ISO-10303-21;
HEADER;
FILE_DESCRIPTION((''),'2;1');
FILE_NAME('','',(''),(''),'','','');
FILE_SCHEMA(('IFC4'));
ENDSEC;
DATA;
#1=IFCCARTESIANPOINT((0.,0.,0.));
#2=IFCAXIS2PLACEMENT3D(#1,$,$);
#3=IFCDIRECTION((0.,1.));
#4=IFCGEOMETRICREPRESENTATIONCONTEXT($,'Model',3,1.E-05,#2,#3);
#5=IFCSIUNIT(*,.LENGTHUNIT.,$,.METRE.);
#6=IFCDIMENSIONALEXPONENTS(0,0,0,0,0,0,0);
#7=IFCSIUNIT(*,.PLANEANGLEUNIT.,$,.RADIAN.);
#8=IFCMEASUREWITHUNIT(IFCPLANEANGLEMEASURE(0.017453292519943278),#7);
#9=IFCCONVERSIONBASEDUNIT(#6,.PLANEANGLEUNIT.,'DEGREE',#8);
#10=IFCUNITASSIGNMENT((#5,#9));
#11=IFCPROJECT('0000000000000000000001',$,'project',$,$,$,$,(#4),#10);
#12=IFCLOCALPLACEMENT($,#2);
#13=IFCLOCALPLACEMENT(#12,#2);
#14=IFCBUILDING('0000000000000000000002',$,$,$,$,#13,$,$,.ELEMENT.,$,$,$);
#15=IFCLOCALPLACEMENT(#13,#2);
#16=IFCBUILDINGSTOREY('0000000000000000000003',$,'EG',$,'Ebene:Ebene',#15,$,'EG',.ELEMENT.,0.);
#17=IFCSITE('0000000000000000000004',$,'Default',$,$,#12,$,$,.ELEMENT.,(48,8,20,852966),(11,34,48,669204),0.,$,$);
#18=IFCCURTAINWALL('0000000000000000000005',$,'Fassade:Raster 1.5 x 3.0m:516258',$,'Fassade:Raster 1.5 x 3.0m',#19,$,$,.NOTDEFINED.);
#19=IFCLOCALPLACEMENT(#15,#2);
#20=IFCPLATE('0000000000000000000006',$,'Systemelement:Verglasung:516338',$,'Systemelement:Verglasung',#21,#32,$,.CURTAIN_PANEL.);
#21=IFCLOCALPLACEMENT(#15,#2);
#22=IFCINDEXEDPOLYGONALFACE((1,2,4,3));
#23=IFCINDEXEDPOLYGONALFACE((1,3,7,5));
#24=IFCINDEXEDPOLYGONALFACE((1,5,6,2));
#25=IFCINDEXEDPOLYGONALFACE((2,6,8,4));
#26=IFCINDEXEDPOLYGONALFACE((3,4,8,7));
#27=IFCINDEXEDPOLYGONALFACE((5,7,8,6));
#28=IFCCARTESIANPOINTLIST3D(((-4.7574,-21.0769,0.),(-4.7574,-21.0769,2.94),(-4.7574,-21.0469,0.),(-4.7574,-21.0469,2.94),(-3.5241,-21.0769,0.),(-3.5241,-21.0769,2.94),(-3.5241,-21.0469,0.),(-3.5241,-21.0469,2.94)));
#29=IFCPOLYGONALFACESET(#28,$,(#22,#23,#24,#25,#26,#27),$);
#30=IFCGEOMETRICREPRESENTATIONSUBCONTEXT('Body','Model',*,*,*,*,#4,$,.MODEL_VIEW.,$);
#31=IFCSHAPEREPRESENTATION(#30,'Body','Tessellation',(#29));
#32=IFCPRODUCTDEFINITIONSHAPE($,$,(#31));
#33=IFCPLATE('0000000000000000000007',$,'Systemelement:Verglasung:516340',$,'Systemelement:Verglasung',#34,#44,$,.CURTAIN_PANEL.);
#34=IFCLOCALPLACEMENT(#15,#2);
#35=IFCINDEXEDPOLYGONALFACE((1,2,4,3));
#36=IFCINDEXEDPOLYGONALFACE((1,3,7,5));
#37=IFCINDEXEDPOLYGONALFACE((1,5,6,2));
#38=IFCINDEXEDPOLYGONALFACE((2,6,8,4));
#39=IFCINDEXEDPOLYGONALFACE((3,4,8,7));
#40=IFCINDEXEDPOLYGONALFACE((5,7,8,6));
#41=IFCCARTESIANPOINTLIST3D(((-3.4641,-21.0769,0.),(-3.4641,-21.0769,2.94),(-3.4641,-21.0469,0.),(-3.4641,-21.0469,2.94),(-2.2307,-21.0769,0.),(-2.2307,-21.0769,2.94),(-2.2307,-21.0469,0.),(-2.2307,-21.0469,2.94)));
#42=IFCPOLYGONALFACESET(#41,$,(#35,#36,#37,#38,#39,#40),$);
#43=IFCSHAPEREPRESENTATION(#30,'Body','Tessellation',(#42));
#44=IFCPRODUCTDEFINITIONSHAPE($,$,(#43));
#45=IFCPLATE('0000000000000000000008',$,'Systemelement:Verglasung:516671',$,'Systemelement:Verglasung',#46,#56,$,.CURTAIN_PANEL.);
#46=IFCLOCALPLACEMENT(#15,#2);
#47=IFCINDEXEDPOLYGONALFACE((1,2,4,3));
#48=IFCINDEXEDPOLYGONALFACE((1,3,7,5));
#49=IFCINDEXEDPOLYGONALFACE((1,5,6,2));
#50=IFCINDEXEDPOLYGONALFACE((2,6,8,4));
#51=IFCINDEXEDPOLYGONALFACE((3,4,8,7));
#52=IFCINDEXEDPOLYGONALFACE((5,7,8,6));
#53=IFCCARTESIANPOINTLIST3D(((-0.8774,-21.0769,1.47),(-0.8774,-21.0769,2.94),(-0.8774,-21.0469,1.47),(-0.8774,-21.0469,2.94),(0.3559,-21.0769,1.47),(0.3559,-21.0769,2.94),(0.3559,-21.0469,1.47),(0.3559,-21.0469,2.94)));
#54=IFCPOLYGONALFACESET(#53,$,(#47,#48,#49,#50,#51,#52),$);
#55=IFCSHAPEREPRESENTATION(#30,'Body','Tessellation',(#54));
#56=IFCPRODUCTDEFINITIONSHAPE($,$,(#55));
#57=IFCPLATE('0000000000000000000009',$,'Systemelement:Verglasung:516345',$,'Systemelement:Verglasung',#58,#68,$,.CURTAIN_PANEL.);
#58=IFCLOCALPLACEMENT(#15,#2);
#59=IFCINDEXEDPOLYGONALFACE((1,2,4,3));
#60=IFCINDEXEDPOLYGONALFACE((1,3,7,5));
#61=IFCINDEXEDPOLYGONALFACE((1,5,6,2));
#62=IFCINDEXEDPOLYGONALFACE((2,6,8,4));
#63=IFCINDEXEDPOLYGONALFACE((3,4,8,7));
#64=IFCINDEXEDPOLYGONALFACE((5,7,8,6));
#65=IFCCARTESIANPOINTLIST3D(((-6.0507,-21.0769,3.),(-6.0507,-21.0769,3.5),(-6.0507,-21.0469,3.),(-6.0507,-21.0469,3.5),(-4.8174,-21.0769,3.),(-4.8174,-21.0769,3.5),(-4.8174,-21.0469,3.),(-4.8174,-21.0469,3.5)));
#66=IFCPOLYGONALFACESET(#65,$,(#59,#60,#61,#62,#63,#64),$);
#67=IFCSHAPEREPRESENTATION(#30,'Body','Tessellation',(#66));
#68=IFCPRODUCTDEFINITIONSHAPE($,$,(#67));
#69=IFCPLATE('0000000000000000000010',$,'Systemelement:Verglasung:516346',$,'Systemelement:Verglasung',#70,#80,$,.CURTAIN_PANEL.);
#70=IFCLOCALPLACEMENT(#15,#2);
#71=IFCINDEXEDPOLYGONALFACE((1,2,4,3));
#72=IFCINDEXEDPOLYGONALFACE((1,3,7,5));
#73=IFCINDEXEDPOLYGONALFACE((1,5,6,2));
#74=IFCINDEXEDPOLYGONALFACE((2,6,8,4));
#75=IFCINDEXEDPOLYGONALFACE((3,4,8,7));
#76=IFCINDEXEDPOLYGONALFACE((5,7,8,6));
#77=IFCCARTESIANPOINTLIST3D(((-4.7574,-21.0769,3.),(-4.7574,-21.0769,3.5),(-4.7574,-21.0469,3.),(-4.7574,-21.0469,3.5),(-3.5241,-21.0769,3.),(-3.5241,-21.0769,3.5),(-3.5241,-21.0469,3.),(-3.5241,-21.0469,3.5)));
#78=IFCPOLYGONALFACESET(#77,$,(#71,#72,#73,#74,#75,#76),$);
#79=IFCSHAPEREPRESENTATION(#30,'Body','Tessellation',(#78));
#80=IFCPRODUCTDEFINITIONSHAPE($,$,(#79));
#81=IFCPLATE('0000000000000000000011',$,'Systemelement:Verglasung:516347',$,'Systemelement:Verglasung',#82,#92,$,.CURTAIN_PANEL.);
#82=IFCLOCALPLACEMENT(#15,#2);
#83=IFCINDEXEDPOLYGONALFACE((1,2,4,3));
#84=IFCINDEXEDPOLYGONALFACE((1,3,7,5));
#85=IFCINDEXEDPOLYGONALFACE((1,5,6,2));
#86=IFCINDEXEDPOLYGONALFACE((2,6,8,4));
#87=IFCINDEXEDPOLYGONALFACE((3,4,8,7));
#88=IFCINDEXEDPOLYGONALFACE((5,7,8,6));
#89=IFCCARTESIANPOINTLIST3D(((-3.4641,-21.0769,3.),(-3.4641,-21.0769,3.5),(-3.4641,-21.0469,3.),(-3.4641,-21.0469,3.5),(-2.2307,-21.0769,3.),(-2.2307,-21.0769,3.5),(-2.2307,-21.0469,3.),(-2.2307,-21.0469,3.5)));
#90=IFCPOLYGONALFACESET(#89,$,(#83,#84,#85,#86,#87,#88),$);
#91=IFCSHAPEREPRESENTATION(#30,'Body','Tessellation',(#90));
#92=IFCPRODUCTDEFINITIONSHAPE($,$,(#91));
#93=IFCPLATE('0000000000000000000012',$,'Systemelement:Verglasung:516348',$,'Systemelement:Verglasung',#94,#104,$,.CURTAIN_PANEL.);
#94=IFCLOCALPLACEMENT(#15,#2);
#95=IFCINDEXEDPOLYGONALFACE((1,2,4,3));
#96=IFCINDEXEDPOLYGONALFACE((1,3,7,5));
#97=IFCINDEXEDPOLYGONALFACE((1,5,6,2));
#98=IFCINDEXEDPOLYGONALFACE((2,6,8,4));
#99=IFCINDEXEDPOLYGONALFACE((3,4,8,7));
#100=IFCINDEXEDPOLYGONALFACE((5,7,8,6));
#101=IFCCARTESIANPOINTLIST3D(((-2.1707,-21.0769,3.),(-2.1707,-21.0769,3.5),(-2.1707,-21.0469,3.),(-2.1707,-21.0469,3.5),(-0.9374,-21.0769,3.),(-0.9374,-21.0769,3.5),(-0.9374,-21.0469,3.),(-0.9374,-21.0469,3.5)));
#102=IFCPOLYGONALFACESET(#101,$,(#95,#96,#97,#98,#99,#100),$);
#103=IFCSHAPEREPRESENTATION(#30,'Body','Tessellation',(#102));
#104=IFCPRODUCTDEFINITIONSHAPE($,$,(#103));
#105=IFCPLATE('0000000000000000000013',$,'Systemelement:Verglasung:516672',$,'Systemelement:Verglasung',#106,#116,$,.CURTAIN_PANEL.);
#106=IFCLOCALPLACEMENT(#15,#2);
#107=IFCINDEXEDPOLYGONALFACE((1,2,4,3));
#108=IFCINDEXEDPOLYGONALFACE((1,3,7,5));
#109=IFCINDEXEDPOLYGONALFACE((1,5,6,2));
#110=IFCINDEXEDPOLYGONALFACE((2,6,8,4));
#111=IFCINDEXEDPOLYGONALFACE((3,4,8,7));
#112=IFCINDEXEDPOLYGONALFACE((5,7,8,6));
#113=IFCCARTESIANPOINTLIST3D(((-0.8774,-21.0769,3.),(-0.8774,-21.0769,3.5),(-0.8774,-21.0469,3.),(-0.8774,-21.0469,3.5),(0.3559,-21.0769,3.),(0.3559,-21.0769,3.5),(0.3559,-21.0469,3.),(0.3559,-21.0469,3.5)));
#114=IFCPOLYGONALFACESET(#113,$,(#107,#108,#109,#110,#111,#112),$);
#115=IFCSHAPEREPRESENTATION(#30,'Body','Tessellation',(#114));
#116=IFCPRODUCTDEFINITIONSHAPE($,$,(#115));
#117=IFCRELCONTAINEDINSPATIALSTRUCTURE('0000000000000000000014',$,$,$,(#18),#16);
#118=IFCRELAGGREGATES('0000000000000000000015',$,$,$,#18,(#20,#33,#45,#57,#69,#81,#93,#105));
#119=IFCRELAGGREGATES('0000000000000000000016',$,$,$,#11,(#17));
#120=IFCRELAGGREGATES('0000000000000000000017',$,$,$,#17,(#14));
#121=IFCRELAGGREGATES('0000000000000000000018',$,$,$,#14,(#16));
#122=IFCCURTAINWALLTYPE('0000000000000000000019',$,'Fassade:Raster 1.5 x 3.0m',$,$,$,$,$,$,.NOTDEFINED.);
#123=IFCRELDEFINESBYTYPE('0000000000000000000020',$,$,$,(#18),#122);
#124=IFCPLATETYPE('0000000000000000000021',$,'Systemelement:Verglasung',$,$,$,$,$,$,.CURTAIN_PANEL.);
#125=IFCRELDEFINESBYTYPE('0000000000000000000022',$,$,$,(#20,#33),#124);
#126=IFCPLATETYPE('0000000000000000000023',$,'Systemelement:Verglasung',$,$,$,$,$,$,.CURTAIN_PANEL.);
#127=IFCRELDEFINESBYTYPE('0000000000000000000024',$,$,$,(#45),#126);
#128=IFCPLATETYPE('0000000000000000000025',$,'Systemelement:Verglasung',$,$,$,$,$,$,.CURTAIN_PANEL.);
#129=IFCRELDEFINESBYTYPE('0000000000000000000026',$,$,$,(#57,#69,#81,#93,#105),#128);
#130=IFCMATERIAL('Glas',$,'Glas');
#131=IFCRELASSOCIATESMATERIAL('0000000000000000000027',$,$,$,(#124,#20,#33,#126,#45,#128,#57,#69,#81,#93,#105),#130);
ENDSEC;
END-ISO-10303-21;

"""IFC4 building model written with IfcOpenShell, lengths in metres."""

from ifc_helpers import new_model, entity, si_unit, converted_unit, direction, frame, origin, place, context, subcontext, project, spatial, indexed_curve, outline, extrude, source, transform, mapped, material, type_object, type_shapes, element, aggregate, save


model = new_model("IFC4")

# Units and contexts
model_context = context("Model", 3, precision=1e-05, world=origin(), true_north=direction((0.0, 1.0)))
body_context = subcontext(model_context, "Body", "Model", "MODEL_VIEW")
ifc_project = project(units=[si_unit("LENGTHUNIT", "METRE"), converted_unit("PLANEANGLEUNIT", "DEGREE", entity("IfcPlaneAngleMeasure", 0.017453292519943278), si_unit("PLANEANGLEUNIT", "RADIAN"), dimensions=[0, 0, 0, 0, 0, 0, 0])], contexts=[model_context])

# Site, building, storey
site_placement = place(None, origin())
site = spatial("IfcSite", under=ifc_project, at=site_placement, Name="Default", CompositionType="ELEMENT", RefLatitude=(48, 8, 20, 852966), RefLongitude=(11, 34, 48, 669204), RefElevation=0.0)
building_placement = place(site_placement, origin())
building = spatial("IfcBuilding", under=site, at=building_placement, CompositionType="ELEMENT")
storey_placement = place(building_placement, origin())
storey = spatial("IfcBuildingStorey", under=building, at=storey_placement, Name="EG", ObjectType="Ebene:Ebene", LongName="EG", CompositionType="ELEMENT", Elevation=0.0)

# Curtain wall, plates
curtain_wall_type = type_object("IfcCurtainWallType", Name="Fassade:Raster 1.5 x 3.0m", PredefinedType="NOTDEFINED")
curtain_wall_placement = place(storey_placement, origin())
curtain_wall = element("IfcCurtainWall", 1, at=curtain_wall_placement, inside=storey, type_object=curtain_wall_type, Name="Fassade:Raster 1.5 x 3.0m:516258", ObjectType="Fassade:Raster 1.5 x 3.0m", PredefinedType="NOTDEFINED")
ifc_material_1 = material(Name="Glas", Category="Glas")
plate_type_1 = type_object("IfcPlateType", Name="Systemelement:Verglasung", PredefinedType="CURTAIN_PANEL", material=ifc_material_1)
shared_shape_1 = source(origin(), body_context, "Body", "SweptSolid", [
    extrude(outline(indexed_curve([(-0.015, -0.6167), (0.015, -0.6167), (0.015, 0.6167), (-0.015, 0.6167), (-0.015, -0.6167)], self_intersect=False)), frame((0.0, 0.0, 0.0), z_axis=(0.0, 0.0, 1.0), x_axis=(0.0, 1.0, 0.0)), (0.0, 0.0, 1.0), 2.94),
])
type_shapes(plate_type_1, [shared_shape_1])
plate_1_placement = place(curtain_wall_placement, frame((-4.1407, -21.0619, 0.0)))
plate_1 = element("IfcPlate", 2, at=plate_1_placement, type_object=plate_type_1, material=ifc_material_1, Name="Systemelement:Verglasung:516338", ObjectType="Systemelement:Verglasung", PredefinedType="CURTAIN_PANEL", context=body_context, shape_type="MappedRepresentation", body=[
    mapped(shared_shape_1, transform((0.0, 0.0, 0.0), scale=1.0)),
])
plate_2_placement = place(curtain_wall_placement, frame((-2.8474, -21.0619, 0.0)))
plate_2 = element("IfcPlate", 3, at=plate_2_placement, type_object=plate_type_1, material=ifc_material_1, Name="Systemelement:Verglasung:516340", ObjectType="Systemelement:Verglasung", PredefinedType="CURTAIN_PANEL", context=body_context, shape_type="MappedRepresentation", body=[
    mapped(shared_shape_1, transform((0.0, 0.0, 0.0), scale=1.0)),
])
plate_type_2 = type_object("IfcPlateType", Name="Systemelement:Verglasung", PredefinedType="CURTAIN_PANEL", material=ifc_material_1)
shared_shape_2 = source(origin(), body_context, "Body", "SweptSolid", [
    extrude(outline(indexed_curve([(-0.015, -0.6167), (0.015, -0.6167), (0.015, 0.6167), (-0.015, 0.6167), (-0.015, -0.6167)], self_intersect=False)), frame((0.0, 0.0, 0.0), z_axis=(0.0, 0.0, 1.0), x_axis=(0.0, 1.0, 0.0)), (0.0, 0.0, 1.0), 1.47),
])
type_shapes(plate_type_2, [shared_shape_2])
plate_3_placement = place(curtain_wall_placement, frame((-0.2607, -21.0619, 1.47)))
plate_3 = element("IfcPlate", 4, at=plate_3_placement, type_object=plate_type_2, material=ifc_material_1, Name="Systemelement:Verglasung:516671", ObjectType="Systemelement:Verglasung", PredefinedType="CURTAIN_PANEL", context=body_context, shape_type="MappedRepresentation", body=[
    mapped(shared_shape_2, transform((0.0, 0.0, 0.0), scale=1.0)),
])
plate_type_3 = type_object("IfcPlateType", Name="Systemelement:Verglasung", PredefinedType="CURTAIN_PANEL", material=ifc_material_1)
shared_shape_3 = source(origin(), body_context, "Body", "SweptSolid", [
    extrude(outline(indexed_curve([(-0.015, -0.6167), (0.015, -0.6167), (0.015, 0.6167), (-0.015, 0.6167), (-0.015, -0.6167)], self_intersect=False)), frame((0.0, 0.0, 0.0), z_axis=(0.0, 0.0, 1.0), x_axis=(0.0, 1.0, 0.0)), (0.0, 0.0, 1.0), 0.5),
])
type_shapes(plate_type_3, [shared_shape_3])
plate_4_placement = place(curtain_wall_placement, frame((-5.4341, -21.0619, 3.0)))
plate_4 = element("IfcPlate", 5, at=plate_4_placement, type_object=plate_type_3, material=ifc_material_1, Name="Systemelement:Verglasung:516345", ObjectType="Systemelement:Verglasung", PredefinedType="CURTAIN_PANEL", context=body_context, shape_type="MappedRepresentation", body=[
    mapped(shared_shape_3, transform((0.0, 0.0, 0.0), scale=1.0)),
])
plate_5_placement = place(curtain_wall_placement, frame((-4.1407, -21.0619, 3.0)))
plate_5 = element("IfcPlate", 6, at=plate_5_placement, type_object=plate_type_3, material=ifc_material_1, Name="Systemelement:Verglasung:516346", ObjectType="Systemelement:Verglasung", PredefinedType="CURTAIN_PANEL", context=body_context, shape_type="MappedRepresentation", body=[
    mapped(shared_shape_3, transform((0.0, 0.0, 0.0), scale=1.0)),
])
plate_6_placement = place(curtain_wall_placement, frame((-2.8474, -21.0619, 3.0)))
plate_6 = element("IfcPlate", 7, at=plate_6_placement, type_object=plate_type_3, material=ifc_material_1, Name="Systemelement:Verglasung:516347", ObjectType="Systemelement:Verglasung", PredefinedType="CURTAIN_PANEL", context=body_context, shape_type="MappedRepresentation", body=[
    mapped(shared_shape_3, transform((0.0, 0.0, 0.0), scale=1.0)),
])
plate_7_placement = place(curtain_wall_placement, frame((-1.5541, -21.0619, 3.0)))
plate_7 = element("IfcPlate", 8, at=plate_7_placement, type_object=plate_type_3, material=ifc_material_1, Name="Systemelement:Verglasung:516348", ObjectType="Systemelement:Verglasung", PredefinedType="CURTAIN_PANEL", context=body_context, shape_type="MappedRepresentation", body=[
    mapped(shared_shape_3, transform((0.0, 0.0, 0.0), scale=1.0)),
])
plate_8_placement = place(curtain_wall_placement, frame((-0.2607, -21.0619, 3.0)))
plate_8 = element("IfcPlate", 9, at=plate_8_placement, type_object=plate_type_3, material=ifc_material_1, Name="Systemelement:Verglasung:516672", ObjectType="Systemelement:Verglasung", PredefinedType="CURTAIN_PANEL", context=body_context, shape_type="MappedRepresentation", body=[
    mapped(shared_shape_3, transform((0.0, 0.0, 0.0), scale=1.0)),
])
aggregate(curtain_wall, [plate_1, plate_2, plate_3, plate_4, plate_5, plate_6, plate_7, plate_8])

save(model, "model.ifc")
